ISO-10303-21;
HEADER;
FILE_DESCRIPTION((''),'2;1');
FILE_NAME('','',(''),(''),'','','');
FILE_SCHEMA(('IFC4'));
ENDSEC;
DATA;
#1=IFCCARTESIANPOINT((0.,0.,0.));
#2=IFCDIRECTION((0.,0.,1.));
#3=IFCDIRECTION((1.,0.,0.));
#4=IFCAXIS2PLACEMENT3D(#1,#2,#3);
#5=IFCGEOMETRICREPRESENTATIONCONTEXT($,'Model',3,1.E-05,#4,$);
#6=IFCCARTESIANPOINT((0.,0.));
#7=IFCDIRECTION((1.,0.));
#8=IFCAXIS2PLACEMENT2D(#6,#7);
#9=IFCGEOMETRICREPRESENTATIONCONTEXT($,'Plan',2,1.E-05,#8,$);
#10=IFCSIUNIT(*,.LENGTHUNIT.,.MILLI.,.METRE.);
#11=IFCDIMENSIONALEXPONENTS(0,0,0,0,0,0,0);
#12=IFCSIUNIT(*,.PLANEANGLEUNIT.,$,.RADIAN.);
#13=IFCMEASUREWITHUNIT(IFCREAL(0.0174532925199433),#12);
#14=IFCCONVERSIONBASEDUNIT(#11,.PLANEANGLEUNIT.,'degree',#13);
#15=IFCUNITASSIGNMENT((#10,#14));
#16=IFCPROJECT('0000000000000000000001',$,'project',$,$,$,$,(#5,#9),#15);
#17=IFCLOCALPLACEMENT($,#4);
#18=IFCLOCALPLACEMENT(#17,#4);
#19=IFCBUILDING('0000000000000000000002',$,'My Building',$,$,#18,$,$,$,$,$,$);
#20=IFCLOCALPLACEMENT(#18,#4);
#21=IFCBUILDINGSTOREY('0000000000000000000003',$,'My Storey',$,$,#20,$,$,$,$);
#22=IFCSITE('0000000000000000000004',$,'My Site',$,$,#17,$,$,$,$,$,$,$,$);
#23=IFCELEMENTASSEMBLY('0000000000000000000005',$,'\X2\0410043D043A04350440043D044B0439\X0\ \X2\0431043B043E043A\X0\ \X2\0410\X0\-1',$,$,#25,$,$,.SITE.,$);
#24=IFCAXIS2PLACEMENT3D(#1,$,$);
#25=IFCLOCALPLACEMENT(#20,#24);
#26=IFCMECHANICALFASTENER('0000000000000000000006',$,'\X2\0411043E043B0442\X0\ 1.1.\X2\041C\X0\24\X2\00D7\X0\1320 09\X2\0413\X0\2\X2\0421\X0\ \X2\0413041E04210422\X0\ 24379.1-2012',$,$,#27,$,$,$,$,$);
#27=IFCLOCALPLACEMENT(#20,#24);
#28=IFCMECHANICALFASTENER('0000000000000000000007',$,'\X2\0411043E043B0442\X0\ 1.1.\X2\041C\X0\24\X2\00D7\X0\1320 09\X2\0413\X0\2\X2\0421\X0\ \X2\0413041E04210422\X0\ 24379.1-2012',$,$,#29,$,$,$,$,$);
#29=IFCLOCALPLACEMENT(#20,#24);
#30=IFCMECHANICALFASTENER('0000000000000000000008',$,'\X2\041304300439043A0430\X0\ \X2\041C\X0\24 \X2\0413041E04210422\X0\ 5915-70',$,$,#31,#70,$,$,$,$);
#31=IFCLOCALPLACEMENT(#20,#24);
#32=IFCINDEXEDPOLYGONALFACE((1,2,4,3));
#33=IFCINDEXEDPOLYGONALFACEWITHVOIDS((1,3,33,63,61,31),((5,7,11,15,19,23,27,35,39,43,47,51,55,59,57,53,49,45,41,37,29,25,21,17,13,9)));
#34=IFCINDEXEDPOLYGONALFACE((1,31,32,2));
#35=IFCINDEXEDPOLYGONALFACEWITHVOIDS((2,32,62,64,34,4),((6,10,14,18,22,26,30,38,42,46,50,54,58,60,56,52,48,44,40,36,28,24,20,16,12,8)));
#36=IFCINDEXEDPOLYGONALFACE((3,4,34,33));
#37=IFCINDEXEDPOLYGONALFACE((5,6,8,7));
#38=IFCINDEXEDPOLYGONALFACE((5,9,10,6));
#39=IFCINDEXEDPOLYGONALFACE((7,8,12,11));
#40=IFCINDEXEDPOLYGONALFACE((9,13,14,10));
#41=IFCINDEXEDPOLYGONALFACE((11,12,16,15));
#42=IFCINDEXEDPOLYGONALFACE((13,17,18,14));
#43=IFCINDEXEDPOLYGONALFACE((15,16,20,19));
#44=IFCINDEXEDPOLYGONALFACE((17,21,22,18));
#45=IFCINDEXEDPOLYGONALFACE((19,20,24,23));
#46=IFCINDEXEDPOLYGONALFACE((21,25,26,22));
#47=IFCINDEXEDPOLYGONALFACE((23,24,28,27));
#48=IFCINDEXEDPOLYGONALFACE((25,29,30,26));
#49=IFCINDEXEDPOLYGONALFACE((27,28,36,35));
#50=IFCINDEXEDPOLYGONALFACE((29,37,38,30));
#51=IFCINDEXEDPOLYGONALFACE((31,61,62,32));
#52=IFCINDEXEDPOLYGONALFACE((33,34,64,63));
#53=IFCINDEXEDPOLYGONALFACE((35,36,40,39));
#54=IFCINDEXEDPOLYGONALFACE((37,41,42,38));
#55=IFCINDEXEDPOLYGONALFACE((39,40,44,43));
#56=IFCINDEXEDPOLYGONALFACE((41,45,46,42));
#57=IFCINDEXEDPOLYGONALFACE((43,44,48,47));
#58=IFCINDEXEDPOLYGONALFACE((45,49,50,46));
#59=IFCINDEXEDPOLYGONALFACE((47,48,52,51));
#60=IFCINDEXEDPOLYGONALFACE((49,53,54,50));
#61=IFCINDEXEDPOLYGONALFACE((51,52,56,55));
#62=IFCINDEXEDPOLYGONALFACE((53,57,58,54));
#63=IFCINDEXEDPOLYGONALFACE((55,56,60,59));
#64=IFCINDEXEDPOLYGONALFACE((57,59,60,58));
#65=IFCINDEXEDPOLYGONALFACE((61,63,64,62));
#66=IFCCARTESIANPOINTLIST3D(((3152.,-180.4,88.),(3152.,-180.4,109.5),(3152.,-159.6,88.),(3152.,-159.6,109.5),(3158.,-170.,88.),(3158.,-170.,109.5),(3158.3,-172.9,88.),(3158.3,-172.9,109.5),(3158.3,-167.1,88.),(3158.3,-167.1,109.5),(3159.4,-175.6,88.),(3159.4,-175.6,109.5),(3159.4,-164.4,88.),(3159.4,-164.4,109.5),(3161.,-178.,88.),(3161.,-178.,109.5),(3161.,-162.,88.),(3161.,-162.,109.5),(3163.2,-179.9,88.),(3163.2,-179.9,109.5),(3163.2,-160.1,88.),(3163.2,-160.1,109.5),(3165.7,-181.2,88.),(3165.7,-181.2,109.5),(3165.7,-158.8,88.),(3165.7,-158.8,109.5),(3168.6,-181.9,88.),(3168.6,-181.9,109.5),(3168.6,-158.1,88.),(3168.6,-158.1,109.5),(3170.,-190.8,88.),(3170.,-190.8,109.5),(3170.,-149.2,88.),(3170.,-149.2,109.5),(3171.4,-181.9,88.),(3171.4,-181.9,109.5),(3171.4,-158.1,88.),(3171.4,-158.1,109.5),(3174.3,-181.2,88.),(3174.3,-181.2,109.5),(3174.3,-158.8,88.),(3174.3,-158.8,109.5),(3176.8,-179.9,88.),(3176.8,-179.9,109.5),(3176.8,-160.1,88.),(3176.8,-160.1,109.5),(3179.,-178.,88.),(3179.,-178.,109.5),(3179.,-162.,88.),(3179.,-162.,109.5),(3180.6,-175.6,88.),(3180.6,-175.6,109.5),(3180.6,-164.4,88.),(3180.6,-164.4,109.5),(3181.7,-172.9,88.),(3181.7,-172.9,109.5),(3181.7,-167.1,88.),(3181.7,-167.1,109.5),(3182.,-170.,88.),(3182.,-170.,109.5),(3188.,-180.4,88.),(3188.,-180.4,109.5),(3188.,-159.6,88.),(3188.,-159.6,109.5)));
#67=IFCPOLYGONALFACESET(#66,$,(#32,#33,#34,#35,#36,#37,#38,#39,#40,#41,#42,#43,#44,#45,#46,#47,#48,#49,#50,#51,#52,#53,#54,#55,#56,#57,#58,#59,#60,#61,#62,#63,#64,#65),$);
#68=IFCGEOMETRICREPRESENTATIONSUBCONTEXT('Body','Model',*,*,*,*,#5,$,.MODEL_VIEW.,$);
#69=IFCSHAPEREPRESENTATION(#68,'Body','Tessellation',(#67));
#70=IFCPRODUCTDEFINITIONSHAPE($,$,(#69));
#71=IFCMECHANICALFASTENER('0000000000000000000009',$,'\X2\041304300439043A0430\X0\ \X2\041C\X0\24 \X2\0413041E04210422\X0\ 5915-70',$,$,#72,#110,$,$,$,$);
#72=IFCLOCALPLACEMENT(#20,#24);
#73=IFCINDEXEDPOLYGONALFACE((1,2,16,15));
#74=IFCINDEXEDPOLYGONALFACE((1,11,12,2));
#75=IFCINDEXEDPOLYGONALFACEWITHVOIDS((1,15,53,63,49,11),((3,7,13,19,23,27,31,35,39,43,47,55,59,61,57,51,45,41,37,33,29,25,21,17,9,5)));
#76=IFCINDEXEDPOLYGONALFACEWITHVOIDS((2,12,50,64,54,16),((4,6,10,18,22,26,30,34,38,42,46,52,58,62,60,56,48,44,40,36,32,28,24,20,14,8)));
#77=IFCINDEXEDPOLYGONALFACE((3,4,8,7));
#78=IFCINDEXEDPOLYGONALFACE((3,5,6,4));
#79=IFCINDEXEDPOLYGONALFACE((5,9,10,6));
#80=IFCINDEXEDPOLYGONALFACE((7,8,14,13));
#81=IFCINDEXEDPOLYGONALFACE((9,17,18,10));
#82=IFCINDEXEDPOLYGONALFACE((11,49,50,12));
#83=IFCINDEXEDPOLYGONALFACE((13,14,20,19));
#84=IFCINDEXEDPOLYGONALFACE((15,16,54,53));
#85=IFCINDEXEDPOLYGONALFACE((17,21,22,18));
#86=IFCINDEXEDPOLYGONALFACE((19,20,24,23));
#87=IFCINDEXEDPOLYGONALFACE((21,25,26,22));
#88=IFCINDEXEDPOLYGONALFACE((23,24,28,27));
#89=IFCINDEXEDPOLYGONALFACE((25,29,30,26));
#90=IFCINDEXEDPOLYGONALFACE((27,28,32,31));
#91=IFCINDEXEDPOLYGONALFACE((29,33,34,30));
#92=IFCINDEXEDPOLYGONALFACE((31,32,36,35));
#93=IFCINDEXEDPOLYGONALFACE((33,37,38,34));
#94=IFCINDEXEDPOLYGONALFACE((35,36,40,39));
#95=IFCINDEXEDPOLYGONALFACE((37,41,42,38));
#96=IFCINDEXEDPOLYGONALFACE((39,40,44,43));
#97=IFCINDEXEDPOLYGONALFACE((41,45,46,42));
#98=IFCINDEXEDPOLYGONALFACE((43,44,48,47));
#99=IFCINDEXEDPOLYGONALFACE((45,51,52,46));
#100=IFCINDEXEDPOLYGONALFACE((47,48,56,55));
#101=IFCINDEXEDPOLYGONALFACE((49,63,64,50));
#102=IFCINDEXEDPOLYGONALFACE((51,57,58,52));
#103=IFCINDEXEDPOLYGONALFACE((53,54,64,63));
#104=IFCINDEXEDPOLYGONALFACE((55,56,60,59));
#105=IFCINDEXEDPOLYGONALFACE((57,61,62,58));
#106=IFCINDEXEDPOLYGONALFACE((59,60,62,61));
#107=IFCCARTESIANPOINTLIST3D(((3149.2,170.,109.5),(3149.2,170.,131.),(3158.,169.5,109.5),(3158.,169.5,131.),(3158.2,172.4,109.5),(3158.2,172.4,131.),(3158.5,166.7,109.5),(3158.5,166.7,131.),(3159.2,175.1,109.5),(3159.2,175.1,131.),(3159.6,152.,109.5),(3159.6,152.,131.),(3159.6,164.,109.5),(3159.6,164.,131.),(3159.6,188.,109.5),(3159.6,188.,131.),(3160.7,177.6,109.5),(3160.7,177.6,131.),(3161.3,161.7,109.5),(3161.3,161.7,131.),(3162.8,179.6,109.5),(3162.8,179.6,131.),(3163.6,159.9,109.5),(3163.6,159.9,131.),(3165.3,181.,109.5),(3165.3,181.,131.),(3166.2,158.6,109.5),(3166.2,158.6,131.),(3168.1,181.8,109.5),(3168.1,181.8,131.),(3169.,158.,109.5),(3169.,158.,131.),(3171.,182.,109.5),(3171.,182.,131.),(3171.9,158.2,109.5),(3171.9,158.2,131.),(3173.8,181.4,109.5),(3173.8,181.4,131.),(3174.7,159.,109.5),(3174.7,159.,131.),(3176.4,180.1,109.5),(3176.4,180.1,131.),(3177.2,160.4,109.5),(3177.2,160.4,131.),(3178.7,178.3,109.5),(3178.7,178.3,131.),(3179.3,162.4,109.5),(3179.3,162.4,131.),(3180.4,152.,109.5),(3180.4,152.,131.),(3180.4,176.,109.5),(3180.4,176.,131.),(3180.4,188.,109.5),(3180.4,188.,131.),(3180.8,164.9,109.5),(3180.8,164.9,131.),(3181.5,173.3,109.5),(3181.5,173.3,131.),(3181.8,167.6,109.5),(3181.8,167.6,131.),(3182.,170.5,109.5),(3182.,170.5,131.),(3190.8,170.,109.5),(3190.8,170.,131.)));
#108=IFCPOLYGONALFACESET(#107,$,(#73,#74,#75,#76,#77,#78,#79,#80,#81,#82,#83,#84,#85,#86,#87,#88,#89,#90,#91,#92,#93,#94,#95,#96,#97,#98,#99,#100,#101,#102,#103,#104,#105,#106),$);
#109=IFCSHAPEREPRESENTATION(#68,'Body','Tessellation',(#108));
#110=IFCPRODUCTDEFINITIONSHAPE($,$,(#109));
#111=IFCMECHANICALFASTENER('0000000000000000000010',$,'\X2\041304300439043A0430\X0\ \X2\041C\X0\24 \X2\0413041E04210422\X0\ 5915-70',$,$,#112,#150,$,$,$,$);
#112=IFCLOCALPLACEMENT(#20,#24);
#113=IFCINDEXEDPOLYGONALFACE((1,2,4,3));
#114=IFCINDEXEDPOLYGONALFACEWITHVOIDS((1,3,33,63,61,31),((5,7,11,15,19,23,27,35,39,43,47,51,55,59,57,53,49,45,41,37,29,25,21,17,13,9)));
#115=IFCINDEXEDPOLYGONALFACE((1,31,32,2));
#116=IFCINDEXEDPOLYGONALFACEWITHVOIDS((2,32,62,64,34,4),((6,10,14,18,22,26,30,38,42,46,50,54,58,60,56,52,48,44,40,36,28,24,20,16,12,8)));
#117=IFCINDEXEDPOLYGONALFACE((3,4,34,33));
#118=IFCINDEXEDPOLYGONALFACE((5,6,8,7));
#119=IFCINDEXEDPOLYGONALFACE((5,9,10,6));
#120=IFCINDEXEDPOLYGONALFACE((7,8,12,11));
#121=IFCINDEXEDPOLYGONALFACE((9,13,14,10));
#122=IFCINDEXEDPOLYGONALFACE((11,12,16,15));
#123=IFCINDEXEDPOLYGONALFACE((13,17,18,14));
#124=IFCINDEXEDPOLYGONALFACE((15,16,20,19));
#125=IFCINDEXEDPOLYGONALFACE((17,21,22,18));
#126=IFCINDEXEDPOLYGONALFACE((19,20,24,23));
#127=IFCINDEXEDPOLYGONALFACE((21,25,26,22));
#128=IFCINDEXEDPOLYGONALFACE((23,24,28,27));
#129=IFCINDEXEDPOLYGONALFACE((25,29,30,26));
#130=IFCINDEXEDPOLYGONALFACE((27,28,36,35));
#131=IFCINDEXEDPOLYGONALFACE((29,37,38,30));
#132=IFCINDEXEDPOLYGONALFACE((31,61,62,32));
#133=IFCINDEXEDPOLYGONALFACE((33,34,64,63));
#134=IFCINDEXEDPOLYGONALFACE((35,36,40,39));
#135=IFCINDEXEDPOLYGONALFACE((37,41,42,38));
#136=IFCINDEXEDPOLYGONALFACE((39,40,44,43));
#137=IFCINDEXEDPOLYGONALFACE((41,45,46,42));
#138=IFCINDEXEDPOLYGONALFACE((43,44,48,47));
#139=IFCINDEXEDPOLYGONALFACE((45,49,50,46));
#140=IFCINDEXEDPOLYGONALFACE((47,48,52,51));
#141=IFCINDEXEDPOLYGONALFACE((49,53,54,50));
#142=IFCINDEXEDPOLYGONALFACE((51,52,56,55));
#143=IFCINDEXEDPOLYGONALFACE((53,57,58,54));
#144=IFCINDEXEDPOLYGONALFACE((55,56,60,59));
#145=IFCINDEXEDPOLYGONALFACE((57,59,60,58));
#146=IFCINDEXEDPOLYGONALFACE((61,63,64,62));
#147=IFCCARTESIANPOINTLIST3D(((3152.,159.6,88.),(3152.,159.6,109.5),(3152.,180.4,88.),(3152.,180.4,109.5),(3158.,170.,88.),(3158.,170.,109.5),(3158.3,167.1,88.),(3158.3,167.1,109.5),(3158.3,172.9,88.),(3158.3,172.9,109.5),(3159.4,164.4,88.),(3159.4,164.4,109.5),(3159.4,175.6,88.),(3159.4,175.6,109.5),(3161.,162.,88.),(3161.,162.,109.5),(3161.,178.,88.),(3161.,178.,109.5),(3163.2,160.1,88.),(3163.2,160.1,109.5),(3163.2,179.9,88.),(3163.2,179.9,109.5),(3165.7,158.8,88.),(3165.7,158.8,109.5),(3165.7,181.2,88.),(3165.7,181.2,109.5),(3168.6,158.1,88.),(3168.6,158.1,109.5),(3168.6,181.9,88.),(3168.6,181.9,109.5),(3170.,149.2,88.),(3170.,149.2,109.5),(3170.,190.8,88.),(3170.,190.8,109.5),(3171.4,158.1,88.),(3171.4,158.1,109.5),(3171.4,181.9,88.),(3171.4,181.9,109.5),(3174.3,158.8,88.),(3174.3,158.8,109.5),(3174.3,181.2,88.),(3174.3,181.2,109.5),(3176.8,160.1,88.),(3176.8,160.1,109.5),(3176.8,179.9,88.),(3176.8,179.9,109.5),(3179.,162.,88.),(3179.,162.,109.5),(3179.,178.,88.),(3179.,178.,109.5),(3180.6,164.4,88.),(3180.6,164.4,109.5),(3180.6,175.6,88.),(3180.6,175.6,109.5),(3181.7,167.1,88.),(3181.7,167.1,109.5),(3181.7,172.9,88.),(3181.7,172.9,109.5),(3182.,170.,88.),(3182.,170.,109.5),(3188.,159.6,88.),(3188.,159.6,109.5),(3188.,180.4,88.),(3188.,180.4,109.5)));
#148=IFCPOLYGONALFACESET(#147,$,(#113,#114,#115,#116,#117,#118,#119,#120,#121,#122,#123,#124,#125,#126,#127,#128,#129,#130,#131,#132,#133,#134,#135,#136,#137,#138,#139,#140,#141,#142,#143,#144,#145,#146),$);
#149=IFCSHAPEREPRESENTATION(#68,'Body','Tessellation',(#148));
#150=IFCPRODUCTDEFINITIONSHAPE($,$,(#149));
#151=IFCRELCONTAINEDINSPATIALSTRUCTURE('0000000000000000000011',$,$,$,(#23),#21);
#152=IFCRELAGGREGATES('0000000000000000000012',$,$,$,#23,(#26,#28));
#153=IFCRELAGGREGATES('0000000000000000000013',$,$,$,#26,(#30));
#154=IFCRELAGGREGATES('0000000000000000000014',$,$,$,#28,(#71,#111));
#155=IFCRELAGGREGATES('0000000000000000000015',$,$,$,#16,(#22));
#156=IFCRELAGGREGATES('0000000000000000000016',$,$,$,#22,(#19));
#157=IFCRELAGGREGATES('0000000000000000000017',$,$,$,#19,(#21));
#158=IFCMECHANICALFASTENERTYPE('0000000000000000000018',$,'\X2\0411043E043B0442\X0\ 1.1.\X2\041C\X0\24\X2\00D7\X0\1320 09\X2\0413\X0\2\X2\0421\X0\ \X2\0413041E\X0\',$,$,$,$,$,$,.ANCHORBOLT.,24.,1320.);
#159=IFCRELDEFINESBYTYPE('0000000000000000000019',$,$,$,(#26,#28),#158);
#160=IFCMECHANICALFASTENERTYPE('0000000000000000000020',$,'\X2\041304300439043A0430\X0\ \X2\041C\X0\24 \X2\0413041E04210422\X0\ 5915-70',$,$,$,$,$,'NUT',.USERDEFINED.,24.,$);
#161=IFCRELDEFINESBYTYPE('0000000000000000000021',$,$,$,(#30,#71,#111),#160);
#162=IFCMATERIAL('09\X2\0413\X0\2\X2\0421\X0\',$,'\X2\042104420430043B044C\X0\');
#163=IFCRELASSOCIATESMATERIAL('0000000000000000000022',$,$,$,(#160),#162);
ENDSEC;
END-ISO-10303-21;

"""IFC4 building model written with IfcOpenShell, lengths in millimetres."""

from ifc_helpers import new_model, entity, si_unit, converted_unit, frame, origin_with_axes, origin_2d_with_axis, place, context, subcontext, project, spatial, polyline, outline, extrude, source, transform, mapped, material, type_object, type_shapes, element, aggregate, save


model = new_model("IFC4")

# Units and contexts
model_context = context("Model", 3, precision=1e-05, world=origin_with_axes())
plan_context = context("Plan", 2, precision=1e-05, world=origin_2d_with_axis())
body_context = subcontext(model_context, "Body", "Model", "MODEL_VIEW")
ifc_project = project(units=[si_unit("LENGTHUNIT", "METRE", prefix="MILLI"), converted_unit("PLANEANGLEUNIT", "degree", entity("IfcReal", 0.0174532925199433), si_unit("PLANEANGLEUNIT", "RADIAN"), dimensions=[0, 0, 0, 0, 0, 0, 0])], contexts=[model_context, plan_context])

# Site, building, storey
site_placement = place(None, origin_with_axes())
site = spatial("IfcSite", under=ifc_project, at=site_placement, Name="My Site")
building_placement = place(site_placement, origin_with_axes())
building = spatial("IfcBuilding", under=site, at=building_placement, Name="My Building")
storey_placement = place(building_placement, origin_with_axes())
storey = spatial("IfcBuildingStorey", under=building, at=storey_placement, Name="My Storey")

# Element assembly, mechanical fasteners
assembly_placement = place(storey_placement, frame((3000.0, 0.0, 0.0), z_axis=(0.0, 0.0, 1.0), x_axis=(1.0, 0.0, 0.0)))
assembly = element("IfcElementAssembly", 1, at=assembly_placement, inside=storey, Name="Анкерный блок А-1", AssemblyPlace="SITE")
mechanical_fastener_type_1 = type_object("IfcMechanicalFastenerType", Name="Болт 1.1.М24×1320 09Г2С ГО", NominalDiameter=24.0, NominalLength=1320.0, PredefinedType="ANCHORBOLT")
ifc_material_1 = material(Name="09Г2С", Category="Сталь")
mechanical_fastener_1_placement = place(assembly_placement, frame((170.0, -170.0, 0.0), z_axis=(0.0, 0.0, 1.0), x_axis=(1.0, 0.0, 0.0)))
mechanical_fastener_1 = element("IfcMechanicalFastener", 2, at=mechanical_fastener_1_placement, type_object=mechanical_fastener_type_1, Name="Болт 1.1.М24×1320 09Г2С ГОСТ 24379.1-2012")
mechanical_fastener_2_placement = place(assembly_placement, frame((170.0, 170.0, 0.0), z_axis=(0.0, 0.0, 1.0), x_axis=(-1.0, 0.0, 0.0)))
mechanical_fastener_2 = element("IfcMechanicalFastener", 3, at=mechanical_fastener_2_placement, type_object=mechanical_fastener_type_1, Name="Болт 1.1.М24×1320 09Г2С ГОСТ 24379.1-2012")
aggregate(assembly, [mechanical_fastener_1, mechanical_fastener_2])
mechanical_fastener_type_2 = type_object("IfcMechanicalFastenerType", Name="Гайка М24 ГОСТ 5915-70", ElementType="NUT", NominalDiameter=24.0, PredefinedType="USERDEFINED", material=ifc_material_1)
shared_shape_1 = source(origin_with_axes(), body_context, "Body", "SweptSolid", [
    extrude(outline(polyline([(-10.4, -18.0), (10.4, -18.0), (20.8, 0.0), (10.4, 18.0), (-10.4, 18.0), (-20.8, 0.0), (-10.4, -18.0)]), holes=[polyline([(-8.0, 9.0), (-5.6, 10.6), (-2.9, 11.7), (0.0, 12.0), (2.9, 11.7), (5.6, 10.6), (8.0, 9.0), (9.9, 6.8), (11.2, 4.3), (11.9, 1.4), (11.9, -1.4), (11.2, -4.3), (9.9, -6.8), (8.0, -9.0), (5.6, -10.6), (2.9, -11.7), (0.0, -12.0), (-2.9, -11.7), (-5.6, -10.6), (-8.0, -9.0), (-9.9, -6.8), (-11.2, -4.3), (-11.9, -1.4), (-11.9, 1.4), (-11.2, 4.3), (-9.9, 6.8), (-8.0, 9.0)])]), frame((0.0, 0.0, 0.0), z_axis=(0.0, 0.0, 1.0), x_axis=(0.0, 1.0, 0.0)), (0.0, 0.0, 1.0), 21.5),
])
type_shapes(mechanical_fastener_type_2, [shared_shape_1])
mechanical_fastener_3_placement = place(mechanical_fastener_1_placement, frame((0.0, 0.0, 88.0), z_axis=(0.0, 0.0, 1.0), x_axis=(1.0, 0.0, 0.0)))
mechanical_fastener_3 = element("IfcMechanicalFastener", 4, at=mechanical_fastener_3_placement, type_object=mechanical_fastener_type_2, Name="Гайка М24 ГОСТ 5915-70", context=body_context, shape_type="MappedRepresentation", body=[
    mapped(shared_shape_1, transform((0.0, 0.0, 0.0), x_axis=(1.0, 0.0, 0.0), y_axis=(0.0, 1.0, 0.0), z_axis=(0.0, 0.0, 1.0), scale=1.0)),
])
mechanical_fastener_4_placement = place(mechanical_fastener_2_placement, frame((0.0, 0.0, 109.5), z_axis=(0.0, 0.0, 1.0), x_axis=(0.866025, 0.5, 0.0)))
mechanical_fastener_4 = element("IfcMechanicalFastener", 5, at=mechanical_fastener_4_placement, type_object=mechanical_fastener_type_2, Name="Гайка М24 ГОСТ 5915-70", context=body_context, shape_type="MappedRepresentation", body=[
    mapped(shared_shape_1, transform((0.0, 0.0, 0.0), x_axis=(1.0, 0.0, 0.0), y_axis=(0.0, 1.0, 0.0), z_axis=(0.0, 0.0, 1.0), scale=1.0)),
])
mechanical_fastener_5_placement = place(mechanical_fastener_2_placement, frame((0.0, 0.0, 88.0), z_axis=(0.0, 0.0, 1.0), x_axis=(1.0, 0.0, 0.0)))
mechanical_fastener_5 = element("IfcMechanicalFastener", 6, at=mechanical_fastener_5_placement, type_object=mechanical_fastener_type_2, Name="Гайка М24 ГОСТ 5915-70", context=body_context, shape_type="MappedRepresentation", body=[
    mapped(shared_shape_1, transform((0.0, 0.0, 0.0), x_axis=(1.0, 0.0, 0.0), y_axis=(0.0, 1.0, 0.0), z_axis=(0.0, 0.0, 1.0), scale=1.0)),
])
aggregate(mechanical_fastener_1, [mechanical_fastener_3])
aggregate(mechanical_fastener_2, [mechanical_fastener_4, mechanical_fastener_5])

save(model, "model.ifc")
